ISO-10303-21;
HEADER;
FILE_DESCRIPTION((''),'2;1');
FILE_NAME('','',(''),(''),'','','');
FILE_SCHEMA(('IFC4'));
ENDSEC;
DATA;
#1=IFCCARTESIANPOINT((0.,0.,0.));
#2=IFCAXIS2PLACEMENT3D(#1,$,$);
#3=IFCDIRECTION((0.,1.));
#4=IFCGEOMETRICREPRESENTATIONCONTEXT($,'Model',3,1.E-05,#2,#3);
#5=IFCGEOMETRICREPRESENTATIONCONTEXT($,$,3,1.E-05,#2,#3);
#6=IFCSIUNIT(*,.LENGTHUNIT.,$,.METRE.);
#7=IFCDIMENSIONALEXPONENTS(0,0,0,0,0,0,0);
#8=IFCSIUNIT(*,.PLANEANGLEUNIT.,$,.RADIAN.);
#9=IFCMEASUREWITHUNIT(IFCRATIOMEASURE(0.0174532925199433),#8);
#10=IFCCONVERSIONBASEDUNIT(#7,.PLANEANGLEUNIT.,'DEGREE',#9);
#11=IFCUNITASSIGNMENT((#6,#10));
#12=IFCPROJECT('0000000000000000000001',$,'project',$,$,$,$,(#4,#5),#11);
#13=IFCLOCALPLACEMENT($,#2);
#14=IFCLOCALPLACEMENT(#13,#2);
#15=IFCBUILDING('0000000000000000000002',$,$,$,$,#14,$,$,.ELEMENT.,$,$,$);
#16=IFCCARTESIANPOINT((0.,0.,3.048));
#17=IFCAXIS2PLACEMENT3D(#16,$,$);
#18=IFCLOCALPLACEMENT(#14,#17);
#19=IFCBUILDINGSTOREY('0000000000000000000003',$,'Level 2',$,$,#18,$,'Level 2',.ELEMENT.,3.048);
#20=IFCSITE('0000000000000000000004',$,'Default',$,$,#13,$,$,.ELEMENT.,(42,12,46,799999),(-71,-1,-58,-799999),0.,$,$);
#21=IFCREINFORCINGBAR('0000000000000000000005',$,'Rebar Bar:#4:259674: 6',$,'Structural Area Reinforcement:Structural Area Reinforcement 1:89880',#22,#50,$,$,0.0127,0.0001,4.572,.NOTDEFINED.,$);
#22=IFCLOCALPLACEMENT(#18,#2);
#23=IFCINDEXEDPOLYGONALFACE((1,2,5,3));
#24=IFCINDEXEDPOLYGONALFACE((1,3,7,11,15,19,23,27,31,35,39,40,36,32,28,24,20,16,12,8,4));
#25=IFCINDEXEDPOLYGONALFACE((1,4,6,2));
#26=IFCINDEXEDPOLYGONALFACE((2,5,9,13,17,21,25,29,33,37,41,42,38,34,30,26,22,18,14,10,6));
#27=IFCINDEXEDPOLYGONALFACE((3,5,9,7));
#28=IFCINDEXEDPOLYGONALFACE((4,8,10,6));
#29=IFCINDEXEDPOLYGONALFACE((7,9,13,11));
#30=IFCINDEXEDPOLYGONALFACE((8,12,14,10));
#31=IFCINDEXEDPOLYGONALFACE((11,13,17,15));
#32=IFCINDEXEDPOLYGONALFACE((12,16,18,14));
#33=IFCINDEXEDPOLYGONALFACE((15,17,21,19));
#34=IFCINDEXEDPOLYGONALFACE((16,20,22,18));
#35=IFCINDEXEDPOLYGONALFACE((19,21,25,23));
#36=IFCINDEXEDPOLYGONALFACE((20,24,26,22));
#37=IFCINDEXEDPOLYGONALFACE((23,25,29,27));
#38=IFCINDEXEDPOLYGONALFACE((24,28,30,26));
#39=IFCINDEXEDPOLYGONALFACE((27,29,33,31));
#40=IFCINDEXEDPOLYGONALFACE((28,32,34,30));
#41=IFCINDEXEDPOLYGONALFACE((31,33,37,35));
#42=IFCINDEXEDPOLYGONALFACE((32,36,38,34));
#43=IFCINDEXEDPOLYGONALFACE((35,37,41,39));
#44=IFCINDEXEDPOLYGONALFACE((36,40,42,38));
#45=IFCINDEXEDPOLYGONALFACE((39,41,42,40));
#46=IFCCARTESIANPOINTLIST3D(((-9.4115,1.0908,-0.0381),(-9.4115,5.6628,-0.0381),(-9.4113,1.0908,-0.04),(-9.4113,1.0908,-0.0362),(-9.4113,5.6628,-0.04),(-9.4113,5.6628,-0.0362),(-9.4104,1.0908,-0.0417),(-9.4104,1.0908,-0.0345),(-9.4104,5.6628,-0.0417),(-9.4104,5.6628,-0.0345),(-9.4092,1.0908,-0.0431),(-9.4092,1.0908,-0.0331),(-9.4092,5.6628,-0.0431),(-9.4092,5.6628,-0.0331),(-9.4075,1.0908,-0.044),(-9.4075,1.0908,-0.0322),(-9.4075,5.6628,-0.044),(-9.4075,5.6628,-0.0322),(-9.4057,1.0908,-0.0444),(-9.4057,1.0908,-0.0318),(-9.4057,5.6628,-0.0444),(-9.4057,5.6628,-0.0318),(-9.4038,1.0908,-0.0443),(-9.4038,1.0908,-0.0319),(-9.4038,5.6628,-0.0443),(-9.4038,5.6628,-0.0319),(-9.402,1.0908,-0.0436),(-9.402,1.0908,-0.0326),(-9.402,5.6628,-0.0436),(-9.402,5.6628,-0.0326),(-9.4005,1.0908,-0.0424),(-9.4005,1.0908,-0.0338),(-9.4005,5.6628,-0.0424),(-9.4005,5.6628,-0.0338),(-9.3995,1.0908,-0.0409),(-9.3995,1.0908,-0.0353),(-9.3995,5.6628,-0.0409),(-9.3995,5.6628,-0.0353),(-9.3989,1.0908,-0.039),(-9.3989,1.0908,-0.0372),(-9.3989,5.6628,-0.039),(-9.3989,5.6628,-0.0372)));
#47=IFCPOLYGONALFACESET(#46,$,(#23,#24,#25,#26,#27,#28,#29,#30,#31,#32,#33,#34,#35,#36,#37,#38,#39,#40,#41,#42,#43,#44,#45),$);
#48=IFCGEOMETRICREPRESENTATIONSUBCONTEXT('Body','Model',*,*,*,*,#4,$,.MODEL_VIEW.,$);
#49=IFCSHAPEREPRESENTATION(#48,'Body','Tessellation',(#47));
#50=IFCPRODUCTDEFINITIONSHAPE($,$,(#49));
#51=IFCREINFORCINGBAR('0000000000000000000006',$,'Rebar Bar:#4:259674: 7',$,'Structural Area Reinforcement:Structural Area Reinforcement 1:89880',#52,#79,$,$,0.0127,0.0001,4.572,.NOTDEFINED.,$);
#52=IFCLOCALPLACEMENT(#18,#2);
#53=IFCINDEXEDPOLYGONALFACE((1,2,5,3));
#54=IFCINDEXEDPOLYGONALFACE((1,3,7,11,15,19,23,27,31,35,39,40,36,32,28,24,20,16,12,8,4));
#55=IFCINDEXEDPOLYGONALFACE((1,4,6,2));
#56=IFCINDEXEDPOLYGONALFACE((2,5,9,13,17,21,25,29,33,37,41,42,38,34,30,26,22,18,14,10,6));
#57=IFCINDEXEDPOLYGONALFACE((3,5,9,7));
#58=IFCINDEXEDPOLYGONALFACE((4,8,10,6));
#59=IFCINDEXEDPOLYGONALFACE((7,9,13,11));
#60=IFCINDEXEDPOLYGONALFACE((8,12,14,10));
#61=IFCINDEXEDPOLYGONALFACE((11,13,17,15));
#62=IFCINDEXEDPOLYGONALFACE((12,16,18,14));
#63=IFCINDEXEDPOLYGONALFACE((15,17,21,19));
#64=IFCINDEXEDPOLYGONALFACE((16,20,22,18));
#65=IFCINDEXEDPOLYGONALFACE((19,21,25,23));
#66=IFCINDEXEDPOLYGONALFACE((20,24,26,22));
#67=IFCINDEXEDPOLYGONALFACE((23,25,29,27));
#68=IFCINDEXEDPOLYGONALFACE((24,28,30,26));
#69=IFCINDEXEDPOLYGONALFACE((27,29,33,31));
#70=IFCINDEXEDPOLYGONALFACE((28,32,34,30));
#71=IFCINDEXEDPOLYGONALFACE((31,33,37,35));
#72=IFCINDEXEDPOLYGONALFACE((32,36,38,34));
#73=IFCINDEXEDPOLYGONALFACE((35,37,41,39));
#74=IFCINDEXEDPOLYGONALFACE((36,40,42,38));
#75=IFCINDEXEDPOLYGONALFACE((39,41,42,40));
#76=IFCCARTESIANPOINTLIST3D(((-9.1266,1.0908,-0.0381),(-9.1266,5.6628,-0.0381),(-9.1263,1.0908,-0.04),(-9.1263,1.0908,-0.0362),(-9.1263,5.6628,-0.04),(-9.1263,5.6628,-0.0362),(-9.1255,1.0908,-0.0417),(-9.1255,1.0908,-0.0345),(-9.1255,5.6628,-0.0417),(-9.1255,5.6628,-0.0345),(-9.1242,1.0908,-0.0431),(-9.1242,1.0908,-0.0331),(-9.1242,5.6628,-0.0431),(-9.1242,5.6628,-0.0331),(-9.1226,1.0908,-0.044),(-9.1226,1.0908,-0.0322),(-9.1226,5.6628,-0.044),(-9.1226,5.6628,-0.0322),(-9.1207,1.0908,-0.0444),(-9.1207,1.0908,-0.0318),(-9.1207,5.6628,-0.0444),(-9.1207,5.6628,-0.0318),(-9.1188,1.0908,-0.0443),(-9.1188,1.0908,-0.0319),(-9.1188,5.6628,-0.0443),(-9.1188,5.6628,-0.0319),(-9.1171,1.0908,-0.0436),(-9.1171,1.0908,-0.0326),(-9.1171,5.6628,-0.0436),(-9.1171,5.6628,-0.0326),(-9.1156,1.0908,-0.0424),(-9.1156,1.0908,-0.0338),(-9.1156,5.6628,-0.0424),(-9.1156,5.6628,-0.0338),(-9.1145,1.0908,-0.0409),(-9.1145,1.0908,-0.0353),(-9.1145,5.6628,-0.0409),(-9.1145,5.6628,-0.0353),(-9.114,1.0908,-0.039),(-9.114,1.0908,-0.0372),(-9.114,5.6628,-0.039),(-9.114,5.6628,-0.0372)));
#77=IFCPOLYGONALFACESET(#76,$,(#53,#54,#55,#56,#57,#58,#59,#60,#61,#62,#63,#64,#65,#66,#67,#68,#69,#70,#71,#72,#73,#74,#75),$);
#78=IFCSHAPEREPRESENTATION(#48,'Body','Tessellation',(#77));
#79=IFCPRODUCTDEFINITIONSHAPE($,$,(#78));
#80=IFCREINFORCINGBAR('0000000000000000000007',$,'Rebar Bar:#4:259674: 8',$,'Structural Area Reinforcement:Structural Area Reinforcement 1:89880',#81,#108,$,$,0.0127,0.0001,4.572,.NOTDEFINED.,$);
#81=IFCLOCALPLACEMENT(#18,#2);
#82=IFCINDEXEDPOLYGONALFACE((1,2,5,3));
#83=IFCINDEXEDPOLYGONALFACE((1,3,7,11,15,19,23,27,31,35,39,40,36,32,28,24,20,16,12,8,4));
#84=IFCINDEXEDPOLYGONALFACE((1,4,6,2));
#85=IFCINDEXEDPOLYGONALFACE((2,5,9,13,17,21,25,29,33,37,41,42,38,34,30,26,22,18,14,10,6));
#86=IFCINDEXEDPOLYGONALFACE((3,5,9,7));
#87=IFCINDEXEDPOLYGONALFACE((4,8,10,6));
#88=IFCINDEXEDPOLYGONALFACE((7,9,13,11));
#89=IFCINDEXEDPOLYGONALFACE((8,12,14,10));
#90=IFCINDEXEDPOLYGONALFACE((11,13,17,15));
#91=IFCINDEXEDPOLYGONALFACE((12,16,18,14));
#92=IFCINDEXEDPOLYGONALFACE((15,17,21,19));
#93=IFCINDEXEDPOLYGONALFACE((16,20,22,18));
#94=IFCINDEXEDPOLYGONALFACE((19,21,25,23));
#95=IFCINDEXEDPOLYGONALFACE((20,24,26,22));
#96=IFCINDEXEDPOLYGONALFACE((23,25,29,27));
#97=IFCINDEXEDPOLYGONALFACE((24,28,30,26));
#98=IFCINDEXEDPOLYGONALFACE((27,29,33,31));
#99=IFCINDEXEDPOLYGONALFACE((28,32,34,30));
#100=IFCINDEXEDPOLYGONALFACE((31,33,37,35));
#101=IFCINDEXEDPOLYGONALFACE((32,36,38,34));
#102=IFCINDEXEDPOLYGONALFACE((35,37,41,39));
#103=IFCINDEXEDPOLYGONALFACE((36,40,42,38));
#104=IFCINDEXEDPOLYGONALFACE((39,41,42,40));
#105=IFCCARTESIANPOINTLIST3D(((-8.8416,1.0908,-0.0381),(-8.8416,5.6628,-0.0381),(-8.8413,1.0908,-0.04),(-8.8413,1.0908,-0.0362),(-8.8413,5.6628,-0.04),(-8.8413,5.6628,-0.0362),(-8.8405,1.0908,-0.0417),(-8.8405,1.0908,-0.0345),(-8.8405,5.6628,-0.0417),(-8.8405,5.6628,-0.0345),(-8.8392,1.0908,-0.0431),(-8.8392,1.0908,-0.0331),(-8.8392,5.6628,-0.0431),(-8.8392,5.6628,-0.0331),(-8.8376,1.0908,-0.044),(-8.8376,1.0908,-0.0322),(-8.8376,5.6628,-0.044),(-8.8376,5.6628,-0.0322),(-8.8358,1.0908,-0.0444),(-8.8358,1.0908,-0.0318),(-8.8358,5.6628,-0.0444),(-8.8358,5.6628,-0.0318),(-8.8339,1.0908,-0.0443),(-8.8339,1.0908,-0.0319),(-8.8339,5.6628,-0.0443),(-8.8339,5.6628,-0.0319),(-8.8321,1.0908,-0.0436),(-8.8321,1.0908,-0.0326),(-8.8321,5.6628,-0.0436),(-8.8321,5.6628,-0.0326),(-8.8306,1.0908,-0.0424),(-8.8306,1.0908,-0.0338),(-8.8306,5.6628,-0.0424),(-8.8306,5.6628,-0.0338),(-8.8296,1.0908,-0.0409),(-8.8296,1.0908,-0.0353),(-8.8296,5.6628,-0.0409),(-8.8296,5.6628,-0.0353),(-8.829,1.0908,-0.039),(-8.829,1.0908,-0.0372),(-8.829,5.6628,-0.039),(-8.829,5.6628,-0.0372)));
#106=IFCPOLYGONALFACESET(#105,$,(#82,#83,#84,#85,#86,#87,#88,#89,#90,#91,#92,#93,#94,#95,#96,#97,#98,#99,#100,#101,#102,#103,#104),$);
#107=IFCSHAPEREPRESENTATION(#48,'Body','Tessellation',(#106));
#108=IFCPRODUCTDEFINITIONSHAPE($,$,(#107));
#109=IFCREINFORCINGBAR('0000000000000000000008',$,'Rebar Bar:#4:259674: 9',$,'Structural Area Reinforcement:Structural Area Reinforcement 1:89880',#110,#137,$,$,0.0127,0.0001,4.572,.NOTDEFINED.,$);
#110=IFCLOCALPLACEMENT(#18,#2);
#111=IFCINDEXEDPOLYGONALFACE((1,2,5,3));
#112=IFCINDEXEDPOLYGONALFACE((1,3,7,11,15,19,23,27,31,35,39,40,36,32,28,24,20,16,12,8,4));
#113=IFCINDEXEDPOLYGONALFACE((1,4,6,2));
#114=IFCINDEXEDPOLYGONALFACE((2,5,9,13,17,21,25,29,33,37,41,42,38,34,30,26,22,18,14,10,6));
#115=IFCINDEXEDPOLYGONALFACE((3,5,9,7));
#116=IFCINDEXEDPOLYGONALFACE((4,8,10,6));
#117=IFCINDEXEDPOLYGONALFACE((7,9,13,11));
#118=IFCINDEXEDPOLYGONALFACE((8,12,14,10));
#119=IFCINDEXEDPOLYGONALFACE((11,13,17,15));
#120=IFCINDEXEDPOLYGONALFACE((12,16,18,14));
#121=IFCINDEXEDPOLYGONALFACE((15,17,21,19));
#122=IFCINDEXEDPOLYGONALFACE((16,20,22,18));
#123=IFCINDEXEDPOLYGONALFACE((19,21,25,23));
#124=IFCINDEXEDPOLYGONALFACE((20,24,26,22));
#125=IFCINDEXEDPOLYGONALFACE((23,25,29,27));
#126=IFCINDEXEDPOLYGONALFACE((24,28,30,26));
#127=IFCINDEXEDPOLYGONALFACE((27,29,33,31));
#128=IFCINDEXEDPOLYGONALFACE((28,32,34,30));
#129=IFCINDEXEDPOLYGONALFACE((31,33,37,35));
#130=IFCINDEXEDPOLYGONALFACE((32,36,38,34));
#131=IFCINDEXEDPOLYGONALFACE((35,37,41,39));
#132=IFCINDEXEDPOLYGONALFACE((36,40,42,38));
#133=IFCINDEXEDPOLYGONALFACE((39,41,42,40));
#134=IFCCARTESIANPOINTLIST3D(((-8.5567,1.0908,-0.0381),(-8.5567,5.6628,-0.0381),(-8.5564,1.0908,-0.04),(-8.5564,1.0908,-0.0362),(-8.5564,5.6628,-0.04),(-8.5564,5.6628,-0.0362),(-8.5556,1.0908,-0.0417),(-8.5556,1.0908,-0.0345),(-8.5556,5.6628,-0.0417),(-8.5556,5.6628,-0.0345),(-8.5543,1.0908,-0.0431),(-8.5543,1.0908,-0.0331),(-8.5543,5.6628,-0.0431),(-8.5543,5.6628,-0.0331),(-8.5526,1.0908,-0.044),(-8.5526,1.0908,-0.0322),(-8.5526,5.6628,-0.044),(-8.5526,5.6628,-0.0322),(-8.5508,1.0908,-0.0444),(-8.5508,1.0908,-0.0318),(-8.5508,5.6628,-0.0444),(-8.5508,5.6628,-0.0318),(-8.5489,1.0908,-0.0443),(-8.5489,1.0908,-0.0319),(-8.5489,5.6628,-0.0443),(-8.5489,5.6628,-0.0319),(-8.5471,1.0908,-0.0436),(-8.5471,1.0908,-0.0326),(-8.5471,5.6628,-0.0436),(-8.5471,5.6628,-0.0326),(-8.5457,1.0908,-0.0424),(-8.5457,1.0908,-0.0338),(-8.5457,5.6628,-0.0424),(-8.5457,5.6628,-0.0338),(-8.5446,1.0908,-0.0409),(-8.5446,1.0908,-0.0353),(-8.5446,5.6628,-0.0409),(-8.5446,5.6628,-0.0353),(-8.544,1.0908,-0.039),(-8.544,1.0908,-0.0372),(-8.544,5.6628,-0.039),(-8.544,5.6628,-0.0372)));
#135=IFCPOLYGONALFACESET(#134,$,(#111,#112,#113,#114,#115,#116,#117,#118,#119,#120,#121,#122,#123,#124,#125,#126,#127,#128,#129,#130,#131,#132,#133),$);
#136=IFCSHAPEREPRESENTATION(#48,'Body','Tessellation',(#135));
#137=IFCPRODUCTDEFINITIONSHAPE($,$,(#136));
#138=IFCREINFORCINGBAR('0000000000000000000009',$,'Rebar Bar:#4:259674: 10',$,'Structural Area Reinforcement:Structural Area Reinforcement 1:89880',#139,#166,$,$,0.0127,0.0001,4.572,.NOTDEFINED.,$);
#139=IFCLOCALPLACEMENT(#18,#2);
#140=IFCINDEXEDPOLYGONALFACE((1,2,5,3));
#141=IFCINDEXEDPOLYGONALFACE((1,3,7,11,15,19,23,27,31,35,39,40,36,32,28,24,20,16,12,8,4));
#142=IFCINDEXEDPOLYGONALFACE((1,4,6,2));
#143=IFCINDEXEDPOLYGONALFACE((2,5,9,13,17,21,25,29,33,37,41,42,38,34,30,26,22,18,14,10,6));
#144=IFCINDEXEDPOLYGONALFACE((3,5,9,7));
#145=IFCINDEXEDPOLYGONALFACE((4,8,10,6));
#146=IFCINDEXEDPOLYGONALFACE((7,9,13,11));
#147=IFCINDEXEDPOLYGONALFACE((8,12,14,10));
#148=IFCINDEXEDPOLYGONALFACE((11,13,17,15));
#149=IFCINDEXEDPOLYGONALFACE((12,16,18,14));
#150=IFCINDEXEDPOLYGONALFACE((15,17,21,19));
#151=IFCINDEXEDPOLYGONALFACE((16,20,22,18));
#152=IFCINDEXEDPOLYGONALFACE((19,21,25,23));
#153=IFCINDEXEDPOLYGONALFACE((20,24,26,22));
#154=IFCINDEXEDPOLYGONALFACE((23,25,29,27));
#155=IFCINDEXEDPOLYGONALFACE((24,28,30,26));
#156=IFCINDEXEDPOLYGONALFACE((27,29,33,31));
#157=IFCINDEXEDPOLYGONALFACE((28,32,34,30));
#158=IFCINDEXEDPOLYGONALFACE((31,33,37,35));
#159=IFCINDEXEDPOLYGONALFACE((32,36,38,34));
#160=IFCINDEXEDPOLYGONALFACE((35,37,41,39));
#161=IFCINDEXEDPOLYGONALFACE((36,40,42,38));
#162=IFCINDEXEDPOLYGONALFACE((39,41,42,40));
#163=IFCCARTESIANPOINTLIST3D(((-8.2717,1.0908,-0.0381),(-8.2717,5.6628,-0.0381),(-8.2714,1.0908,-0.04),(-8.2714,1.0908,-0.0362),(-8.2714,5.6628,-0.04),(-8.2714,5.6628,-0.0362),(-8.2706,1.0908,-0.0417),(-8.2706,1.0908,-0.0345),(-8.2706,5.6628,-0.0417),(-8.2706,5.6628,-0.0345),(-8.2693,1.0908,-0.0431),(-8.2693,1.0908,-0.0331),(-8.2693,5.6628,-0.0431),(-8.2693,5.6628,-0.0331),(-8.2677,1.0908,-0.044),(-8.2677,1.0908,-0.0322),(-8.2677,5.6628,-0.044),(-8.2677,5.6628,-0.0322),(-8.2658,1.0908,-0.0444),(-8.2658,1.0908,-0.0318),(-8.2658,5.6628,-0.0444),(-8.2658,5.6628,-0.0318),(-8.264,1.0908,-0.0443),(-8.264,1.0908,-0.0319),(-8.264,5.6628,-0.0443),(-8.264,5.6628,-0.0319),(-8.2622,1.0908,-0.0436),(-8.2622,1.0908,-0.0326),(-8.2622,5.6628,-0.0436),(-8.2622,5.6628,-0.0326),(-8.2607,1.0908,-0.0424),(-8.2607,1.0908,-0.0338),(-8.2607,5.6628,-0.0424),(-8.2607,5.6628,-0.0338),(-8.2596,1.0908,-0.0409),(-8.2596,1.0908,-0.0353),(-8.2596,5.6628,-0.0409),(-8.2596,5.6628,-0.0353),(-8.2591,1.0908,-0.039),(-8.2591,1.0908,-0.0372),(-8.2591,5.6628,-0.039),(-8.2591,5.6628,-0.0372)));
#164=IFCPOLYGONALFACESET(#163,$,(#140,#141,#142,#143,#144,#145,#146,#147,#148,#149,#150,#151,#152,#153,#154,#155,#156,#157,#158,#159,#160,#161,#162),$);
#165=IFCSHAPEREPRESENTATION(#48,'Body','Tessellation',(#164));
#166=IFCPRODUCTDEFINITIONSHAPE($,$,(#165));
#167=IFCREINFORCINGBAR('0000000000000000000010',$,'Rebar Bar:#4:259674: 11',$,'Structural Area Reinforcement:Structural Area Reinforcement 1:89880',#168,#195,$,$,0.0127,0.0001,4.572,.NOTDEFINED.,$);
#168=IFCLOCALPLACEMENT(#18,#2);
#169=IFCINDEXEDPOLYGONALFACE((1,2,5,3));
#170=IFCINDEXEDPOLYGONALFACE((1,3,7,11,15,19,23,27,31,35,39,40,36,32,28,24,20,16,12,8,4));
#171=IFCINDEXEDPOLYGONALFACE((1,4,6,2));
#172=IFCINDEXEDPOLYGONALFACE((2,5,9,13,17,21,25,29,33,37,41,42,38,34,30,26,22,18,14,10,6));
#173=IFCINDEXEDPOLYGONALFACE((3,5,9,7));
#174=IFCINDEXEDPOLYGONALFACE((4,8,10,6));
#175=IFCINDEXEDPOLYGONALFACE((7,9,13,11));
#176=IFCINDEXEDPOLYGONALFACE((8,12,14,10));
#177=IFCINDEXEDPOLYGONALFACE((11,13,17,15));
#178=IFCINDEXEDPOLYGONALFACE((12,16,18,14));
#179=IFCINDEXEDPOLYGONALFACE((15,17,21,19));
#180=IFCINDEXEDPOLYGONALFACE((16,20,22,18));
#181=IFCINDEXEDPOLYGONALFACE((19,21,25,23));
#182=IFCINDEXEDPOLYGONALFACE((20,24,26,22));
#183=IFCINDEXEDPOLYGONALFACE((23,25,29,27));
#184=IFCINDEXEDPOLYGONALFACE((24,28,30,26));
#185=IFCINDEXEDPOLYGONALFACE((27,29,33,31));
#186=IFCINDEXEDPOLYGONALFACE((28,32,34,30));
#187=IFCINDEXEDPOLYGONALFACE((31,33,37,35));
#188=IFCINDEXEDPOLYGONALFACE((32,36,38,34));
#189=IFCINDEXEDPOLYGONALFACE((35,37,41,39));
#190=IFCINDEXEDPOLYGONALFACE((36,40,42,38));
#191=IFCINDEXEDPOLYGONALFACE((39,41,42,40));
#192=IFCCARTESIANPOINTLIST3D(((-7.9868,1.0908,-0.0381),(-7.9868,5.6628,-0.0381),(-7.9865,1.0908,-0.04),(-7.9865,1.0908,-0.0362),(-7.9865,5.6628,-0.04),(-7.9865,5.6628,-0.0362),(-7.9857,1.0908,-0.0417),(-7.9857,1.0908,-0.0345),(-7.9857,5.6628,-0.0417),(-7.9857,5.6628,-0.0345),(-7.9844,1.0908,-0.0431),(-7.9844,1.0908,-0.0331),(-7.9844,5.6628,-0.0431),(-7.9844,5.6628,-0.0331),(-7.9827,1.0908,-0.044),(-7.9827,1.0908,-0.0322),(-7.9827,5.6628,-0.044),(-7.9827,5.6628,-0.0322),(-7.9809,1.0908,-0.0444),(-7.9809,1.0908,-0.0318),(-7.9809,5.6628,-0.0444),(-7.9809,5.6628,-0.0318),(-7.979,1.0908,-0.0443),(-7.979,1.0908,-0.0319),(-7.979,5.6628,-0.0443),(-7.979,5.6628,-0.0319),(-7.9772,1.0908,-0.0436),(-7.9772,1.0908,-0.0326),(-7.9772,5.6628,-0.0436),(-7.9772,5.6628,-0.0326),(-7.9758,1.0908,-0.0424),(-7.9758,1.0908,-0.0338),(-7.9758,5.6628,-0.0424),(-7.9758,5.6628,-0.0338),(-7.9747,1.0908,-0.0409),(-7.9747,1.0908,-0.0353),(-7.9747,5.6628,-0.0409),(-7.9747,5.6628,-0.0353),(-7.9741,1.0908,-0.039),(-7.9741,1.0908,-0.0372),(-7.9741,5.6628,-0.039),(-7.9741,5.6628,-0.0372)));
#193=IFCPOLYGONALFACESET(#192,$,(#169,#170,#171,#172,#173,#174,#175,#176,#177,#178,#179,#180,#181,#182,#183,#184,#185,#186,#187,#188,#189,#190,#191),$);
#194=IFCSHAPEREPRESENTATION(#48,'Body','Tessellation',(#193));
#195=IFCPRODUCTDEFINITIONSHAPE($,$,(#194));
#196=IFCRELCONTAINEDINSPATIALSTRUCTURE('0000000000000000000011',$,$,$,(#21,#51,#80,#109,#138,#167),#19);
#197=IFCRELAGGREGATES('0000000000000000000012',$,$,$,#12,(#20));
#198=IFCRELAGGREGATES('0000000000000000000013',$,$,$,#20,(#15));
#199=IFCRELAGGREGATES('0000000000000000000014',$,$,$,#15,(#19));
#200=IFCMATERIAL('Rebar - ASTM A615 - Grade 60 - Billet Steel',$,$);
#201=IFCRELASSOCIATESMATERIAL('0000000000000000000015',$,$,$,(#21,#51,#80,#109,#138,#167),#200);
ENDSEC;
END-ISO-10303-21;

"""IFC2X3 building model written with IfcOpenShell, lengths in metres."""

from ifc_helpers import new_model, entity, si_unit, converted_unit, direction, frame, origin, place, context, subcontext, project, spatial, material, element, save


model = new_model("IFC2X3")

# Units and contexts
model_context = context("Model", 3, precision=1e-05, world=origin(), true_north=direction((0.0, 1.0)))
context_of_model = context(None, 3, precision=1e-05, world=origin(), true_north=direction((0.0, 1.0)))
body_context = subcontext(model_context, "Body", "Model", "MODEL_VIEW")
ifc_project = project(units=[si_unit("LENGTHUNIT", "METRE"), converted_unit("PLANEANGLEUNIT", "DEGREE", entity("IfcRatioMeasure", 0.0174532925199433), si_unit("PLANEANGLEUNIT", "RADIAN"), dimensions=[0, 0, 0, 0, 0, 0, 0])], contexts=[model_context, context_of_model])

# Site, building, storey
site_placement = place(None, origin())
site = spatial("IfcSite", under=ifc_project, at=site_placement, Name="Default", CompositionType="ELEMENT", RefLatitude=(42, 12, 46, 799999), RefLongitude=(-71, -1, -58, -799999), RefElevation=0.0)
building_placement = place(site_placement, origin())
building = spatial("IfcBuilding", under=site, at=building_placement, CompositionType="ELEMENT")
storey_placement = place(building_placement, frame((0.0, 0.0, 3.048)))
storey = spatial("IfcBuildingStorey", under=building, at=storey_placement, Name="Level 2", LongName="Level 2", CompositionType="ELEMENT", Elevation=3.048)

# Reinforcing bars
ifc_material_1 = material(Name="Rebar - ASTM A615 - Grade 60 - Billet Steel")
reinforcing_bar_1_placement = place(storey_placement, origin())
element("IfcReinforcingBar", 1, at=reinforcing_bar_1_placement, inside=storey, material=ifc_material_1, Name="Rebar Bar:#4:259674: 6", ObjectType="Structural Area Reinforcement:Structural Area Reinforcement 1:89880", BarLength=4.572, BarRole="NOTDEFINED", CrossSectionArea=0.0001, NominalDiameter=0.0127, context=body_context, shape_type="AdvancedSweptSolid", body=[
    entity("IfcSweptDiskSolid", entity("IfcCompositeCurve", [entity("IfcCompositeCurveSegment", "CONTINUOUS", True, entity("IfcPolyline", [entity("IfcCartesianPoint", [-9.4052, 5.6628, -0.0381]), entity("IfcCartesianPoint", [-9.4052, 1.0908, -0.0381])]))], False), 0.0063, None, 0.0, 1.0),
])
reinforcing_bar_2_placement = place(storey_placement, origin())
element("IfcReinforcingBar", 2, at=reinforcing_bar_2_placement, inside=storey, material=ifc_material_1, Name="Rebar Bar:#4:259674: 7", ObjectType="Structural Area Reinforcement:Structural Area Reinforcement 1:89880", BarLength=4.572, BarRole="NOTDEFINED", CrossSectionArea=0.0001, NominalDiameter=0.0127, context=body_context, shape_type="AdvancedSweptSolid", body=[
    entity("IfcSweptDiskSolid", entity("IfcCompositeCurve", [entity("IfcCompositeCurveSegment", "CONTINUOUS", True, entity("IfcPolyline", [entity("IfcCartesianPoint", [-9.1202, 5.6628, -0.0381]), entity("IfcCartesianPoint", [-9.1202, 1.0908, -0.0381])]))], False), 0.0063, None, 0.0, 1.0),
])
reinforcing_bar_3_placement = place(storey_placement, origin())
element("IfcReinforcingBar", 3, at=reinforcing_bar_3_placement, inside=storey, material=ifc_material_1, Name="Rebar Bar:#4:259674: 8", ObjectType="Structural Area Reinforcement:Structural Area Reinforcement 1:89880", BarLength=4.572, BarRole="NOTDEFINED", CrossSectionArea=0.0001, NominalDiameter=0.0127, context=body_context, shape_type="AdvancedSweptSolid", body=[
    entity("IfcSweptDiskSolid", entity("IfcCompositeCurve", [entity("IfcCompositeCurveSegment", "CONTINUOUS", True, entity("IfcPolyline", [entity("IfcCartesianPoint", [-8.8353, 5.6628, -0.0381]), entity("IfcCartesianPoint", [-8.8353, 1.0908, -0.0381])]))], False), 0.0063, None, 0.0, 1.0),
])
reinforcing_bar_4_placement = place(storey_placement, origin())
element("IfcReinforcingBar", 4, at=reinforcing_bar_4_placement, inside=storey, material=ifc_material_1, Name="Rebar Bar:#4:259674: 9", ObjectType="Structural Area Reinforcement:Structural Area Reinforcement 1:89880", BarLength=4.572, BarRole="NOTDEFINED", CrossSectionArea=0.0001, NominalDiameter=0.0127, context=body_context, shape_type="AdvancedSweptSolid", body=[
    entity("IfcSweptDiskSolid", entity("IfcCompositeCurve", [entity("IfcCompositeCurveSegment", "CONTINUOUS", True, entity("IfcPolyline", [entity("IfcCartesianPoint", [-8.5503, 5.6628, -0.0381]), entity("IfcCartesianPoint", [-8.5503, 1.0908, -0.0381])]))], False), 0.0063, None, 0.0, 1.0),
])
reinforcing_bar_5_placement = place(storey_placement, origin())
element("IfcReinforcingBar", 5, at=reinforcing_bar_5_placement, inside=storey, material=ifc_material_1, Name="Rebar Bar:#4:259674: 10", ObjectType="Structural Area Reinforcement:Structural Area Reinforcement 1:89880", BarLength=4.572, BarRole="NOTDEFINED", CrossSectionArea=0.0001, NominalDiameter=0.0127, context=body_context, shape_type="AdvancedSweptSolid", body=[
    entity("IfcSweptDiskSolid", entity("IfcCompositeCurve", [entity("IfcCompositeCurveSegment", "CONTINUOUS", True, entity("IfcPolyline", [entity("IfcCartesianPoint", [-8.2654, 5.6628, -0.0381]), entity("IfcCartesianPoint", [-8.2654, 1.0908, -0.0381])]))], False), 0.0063, None, 0.0, 1.0),
])
reinforcing_bar_6_placement = place(storey_placement, origin())
element("IfcReinforcingBar", 6, at=reinforcing_bar_6_placement, inside=storey, material=ifc_material_1, Name="Rebar Bar:#4:259674: 11", ObjectType="Structural Area Reinforcement:Structural Area Reinforcement 1:89880", BarLength=4.572, BarRole="NOTDEFINED", CrossSectionArea=0.0001, NominalDiameter=0.0127, context=body_context, shape_type="AdvancedSweptSolid", body=[
    entity("IfcSweptDiskSolid", entity("IfcCompositeCurve", [entity("IfcCompositeCurveSegment", "CONTINUOUS", True, entity("IfcPolyline", [entity("IfcCartesianPoint", [-7.9804, 5.6628, -0.0381]), entity("IfcCartesianPoint", [-7.9804, 1.0908, -0.0381])]))], False), 0.0063, None, 0.0, 1.0),
])

save(model, "model.ifc")
